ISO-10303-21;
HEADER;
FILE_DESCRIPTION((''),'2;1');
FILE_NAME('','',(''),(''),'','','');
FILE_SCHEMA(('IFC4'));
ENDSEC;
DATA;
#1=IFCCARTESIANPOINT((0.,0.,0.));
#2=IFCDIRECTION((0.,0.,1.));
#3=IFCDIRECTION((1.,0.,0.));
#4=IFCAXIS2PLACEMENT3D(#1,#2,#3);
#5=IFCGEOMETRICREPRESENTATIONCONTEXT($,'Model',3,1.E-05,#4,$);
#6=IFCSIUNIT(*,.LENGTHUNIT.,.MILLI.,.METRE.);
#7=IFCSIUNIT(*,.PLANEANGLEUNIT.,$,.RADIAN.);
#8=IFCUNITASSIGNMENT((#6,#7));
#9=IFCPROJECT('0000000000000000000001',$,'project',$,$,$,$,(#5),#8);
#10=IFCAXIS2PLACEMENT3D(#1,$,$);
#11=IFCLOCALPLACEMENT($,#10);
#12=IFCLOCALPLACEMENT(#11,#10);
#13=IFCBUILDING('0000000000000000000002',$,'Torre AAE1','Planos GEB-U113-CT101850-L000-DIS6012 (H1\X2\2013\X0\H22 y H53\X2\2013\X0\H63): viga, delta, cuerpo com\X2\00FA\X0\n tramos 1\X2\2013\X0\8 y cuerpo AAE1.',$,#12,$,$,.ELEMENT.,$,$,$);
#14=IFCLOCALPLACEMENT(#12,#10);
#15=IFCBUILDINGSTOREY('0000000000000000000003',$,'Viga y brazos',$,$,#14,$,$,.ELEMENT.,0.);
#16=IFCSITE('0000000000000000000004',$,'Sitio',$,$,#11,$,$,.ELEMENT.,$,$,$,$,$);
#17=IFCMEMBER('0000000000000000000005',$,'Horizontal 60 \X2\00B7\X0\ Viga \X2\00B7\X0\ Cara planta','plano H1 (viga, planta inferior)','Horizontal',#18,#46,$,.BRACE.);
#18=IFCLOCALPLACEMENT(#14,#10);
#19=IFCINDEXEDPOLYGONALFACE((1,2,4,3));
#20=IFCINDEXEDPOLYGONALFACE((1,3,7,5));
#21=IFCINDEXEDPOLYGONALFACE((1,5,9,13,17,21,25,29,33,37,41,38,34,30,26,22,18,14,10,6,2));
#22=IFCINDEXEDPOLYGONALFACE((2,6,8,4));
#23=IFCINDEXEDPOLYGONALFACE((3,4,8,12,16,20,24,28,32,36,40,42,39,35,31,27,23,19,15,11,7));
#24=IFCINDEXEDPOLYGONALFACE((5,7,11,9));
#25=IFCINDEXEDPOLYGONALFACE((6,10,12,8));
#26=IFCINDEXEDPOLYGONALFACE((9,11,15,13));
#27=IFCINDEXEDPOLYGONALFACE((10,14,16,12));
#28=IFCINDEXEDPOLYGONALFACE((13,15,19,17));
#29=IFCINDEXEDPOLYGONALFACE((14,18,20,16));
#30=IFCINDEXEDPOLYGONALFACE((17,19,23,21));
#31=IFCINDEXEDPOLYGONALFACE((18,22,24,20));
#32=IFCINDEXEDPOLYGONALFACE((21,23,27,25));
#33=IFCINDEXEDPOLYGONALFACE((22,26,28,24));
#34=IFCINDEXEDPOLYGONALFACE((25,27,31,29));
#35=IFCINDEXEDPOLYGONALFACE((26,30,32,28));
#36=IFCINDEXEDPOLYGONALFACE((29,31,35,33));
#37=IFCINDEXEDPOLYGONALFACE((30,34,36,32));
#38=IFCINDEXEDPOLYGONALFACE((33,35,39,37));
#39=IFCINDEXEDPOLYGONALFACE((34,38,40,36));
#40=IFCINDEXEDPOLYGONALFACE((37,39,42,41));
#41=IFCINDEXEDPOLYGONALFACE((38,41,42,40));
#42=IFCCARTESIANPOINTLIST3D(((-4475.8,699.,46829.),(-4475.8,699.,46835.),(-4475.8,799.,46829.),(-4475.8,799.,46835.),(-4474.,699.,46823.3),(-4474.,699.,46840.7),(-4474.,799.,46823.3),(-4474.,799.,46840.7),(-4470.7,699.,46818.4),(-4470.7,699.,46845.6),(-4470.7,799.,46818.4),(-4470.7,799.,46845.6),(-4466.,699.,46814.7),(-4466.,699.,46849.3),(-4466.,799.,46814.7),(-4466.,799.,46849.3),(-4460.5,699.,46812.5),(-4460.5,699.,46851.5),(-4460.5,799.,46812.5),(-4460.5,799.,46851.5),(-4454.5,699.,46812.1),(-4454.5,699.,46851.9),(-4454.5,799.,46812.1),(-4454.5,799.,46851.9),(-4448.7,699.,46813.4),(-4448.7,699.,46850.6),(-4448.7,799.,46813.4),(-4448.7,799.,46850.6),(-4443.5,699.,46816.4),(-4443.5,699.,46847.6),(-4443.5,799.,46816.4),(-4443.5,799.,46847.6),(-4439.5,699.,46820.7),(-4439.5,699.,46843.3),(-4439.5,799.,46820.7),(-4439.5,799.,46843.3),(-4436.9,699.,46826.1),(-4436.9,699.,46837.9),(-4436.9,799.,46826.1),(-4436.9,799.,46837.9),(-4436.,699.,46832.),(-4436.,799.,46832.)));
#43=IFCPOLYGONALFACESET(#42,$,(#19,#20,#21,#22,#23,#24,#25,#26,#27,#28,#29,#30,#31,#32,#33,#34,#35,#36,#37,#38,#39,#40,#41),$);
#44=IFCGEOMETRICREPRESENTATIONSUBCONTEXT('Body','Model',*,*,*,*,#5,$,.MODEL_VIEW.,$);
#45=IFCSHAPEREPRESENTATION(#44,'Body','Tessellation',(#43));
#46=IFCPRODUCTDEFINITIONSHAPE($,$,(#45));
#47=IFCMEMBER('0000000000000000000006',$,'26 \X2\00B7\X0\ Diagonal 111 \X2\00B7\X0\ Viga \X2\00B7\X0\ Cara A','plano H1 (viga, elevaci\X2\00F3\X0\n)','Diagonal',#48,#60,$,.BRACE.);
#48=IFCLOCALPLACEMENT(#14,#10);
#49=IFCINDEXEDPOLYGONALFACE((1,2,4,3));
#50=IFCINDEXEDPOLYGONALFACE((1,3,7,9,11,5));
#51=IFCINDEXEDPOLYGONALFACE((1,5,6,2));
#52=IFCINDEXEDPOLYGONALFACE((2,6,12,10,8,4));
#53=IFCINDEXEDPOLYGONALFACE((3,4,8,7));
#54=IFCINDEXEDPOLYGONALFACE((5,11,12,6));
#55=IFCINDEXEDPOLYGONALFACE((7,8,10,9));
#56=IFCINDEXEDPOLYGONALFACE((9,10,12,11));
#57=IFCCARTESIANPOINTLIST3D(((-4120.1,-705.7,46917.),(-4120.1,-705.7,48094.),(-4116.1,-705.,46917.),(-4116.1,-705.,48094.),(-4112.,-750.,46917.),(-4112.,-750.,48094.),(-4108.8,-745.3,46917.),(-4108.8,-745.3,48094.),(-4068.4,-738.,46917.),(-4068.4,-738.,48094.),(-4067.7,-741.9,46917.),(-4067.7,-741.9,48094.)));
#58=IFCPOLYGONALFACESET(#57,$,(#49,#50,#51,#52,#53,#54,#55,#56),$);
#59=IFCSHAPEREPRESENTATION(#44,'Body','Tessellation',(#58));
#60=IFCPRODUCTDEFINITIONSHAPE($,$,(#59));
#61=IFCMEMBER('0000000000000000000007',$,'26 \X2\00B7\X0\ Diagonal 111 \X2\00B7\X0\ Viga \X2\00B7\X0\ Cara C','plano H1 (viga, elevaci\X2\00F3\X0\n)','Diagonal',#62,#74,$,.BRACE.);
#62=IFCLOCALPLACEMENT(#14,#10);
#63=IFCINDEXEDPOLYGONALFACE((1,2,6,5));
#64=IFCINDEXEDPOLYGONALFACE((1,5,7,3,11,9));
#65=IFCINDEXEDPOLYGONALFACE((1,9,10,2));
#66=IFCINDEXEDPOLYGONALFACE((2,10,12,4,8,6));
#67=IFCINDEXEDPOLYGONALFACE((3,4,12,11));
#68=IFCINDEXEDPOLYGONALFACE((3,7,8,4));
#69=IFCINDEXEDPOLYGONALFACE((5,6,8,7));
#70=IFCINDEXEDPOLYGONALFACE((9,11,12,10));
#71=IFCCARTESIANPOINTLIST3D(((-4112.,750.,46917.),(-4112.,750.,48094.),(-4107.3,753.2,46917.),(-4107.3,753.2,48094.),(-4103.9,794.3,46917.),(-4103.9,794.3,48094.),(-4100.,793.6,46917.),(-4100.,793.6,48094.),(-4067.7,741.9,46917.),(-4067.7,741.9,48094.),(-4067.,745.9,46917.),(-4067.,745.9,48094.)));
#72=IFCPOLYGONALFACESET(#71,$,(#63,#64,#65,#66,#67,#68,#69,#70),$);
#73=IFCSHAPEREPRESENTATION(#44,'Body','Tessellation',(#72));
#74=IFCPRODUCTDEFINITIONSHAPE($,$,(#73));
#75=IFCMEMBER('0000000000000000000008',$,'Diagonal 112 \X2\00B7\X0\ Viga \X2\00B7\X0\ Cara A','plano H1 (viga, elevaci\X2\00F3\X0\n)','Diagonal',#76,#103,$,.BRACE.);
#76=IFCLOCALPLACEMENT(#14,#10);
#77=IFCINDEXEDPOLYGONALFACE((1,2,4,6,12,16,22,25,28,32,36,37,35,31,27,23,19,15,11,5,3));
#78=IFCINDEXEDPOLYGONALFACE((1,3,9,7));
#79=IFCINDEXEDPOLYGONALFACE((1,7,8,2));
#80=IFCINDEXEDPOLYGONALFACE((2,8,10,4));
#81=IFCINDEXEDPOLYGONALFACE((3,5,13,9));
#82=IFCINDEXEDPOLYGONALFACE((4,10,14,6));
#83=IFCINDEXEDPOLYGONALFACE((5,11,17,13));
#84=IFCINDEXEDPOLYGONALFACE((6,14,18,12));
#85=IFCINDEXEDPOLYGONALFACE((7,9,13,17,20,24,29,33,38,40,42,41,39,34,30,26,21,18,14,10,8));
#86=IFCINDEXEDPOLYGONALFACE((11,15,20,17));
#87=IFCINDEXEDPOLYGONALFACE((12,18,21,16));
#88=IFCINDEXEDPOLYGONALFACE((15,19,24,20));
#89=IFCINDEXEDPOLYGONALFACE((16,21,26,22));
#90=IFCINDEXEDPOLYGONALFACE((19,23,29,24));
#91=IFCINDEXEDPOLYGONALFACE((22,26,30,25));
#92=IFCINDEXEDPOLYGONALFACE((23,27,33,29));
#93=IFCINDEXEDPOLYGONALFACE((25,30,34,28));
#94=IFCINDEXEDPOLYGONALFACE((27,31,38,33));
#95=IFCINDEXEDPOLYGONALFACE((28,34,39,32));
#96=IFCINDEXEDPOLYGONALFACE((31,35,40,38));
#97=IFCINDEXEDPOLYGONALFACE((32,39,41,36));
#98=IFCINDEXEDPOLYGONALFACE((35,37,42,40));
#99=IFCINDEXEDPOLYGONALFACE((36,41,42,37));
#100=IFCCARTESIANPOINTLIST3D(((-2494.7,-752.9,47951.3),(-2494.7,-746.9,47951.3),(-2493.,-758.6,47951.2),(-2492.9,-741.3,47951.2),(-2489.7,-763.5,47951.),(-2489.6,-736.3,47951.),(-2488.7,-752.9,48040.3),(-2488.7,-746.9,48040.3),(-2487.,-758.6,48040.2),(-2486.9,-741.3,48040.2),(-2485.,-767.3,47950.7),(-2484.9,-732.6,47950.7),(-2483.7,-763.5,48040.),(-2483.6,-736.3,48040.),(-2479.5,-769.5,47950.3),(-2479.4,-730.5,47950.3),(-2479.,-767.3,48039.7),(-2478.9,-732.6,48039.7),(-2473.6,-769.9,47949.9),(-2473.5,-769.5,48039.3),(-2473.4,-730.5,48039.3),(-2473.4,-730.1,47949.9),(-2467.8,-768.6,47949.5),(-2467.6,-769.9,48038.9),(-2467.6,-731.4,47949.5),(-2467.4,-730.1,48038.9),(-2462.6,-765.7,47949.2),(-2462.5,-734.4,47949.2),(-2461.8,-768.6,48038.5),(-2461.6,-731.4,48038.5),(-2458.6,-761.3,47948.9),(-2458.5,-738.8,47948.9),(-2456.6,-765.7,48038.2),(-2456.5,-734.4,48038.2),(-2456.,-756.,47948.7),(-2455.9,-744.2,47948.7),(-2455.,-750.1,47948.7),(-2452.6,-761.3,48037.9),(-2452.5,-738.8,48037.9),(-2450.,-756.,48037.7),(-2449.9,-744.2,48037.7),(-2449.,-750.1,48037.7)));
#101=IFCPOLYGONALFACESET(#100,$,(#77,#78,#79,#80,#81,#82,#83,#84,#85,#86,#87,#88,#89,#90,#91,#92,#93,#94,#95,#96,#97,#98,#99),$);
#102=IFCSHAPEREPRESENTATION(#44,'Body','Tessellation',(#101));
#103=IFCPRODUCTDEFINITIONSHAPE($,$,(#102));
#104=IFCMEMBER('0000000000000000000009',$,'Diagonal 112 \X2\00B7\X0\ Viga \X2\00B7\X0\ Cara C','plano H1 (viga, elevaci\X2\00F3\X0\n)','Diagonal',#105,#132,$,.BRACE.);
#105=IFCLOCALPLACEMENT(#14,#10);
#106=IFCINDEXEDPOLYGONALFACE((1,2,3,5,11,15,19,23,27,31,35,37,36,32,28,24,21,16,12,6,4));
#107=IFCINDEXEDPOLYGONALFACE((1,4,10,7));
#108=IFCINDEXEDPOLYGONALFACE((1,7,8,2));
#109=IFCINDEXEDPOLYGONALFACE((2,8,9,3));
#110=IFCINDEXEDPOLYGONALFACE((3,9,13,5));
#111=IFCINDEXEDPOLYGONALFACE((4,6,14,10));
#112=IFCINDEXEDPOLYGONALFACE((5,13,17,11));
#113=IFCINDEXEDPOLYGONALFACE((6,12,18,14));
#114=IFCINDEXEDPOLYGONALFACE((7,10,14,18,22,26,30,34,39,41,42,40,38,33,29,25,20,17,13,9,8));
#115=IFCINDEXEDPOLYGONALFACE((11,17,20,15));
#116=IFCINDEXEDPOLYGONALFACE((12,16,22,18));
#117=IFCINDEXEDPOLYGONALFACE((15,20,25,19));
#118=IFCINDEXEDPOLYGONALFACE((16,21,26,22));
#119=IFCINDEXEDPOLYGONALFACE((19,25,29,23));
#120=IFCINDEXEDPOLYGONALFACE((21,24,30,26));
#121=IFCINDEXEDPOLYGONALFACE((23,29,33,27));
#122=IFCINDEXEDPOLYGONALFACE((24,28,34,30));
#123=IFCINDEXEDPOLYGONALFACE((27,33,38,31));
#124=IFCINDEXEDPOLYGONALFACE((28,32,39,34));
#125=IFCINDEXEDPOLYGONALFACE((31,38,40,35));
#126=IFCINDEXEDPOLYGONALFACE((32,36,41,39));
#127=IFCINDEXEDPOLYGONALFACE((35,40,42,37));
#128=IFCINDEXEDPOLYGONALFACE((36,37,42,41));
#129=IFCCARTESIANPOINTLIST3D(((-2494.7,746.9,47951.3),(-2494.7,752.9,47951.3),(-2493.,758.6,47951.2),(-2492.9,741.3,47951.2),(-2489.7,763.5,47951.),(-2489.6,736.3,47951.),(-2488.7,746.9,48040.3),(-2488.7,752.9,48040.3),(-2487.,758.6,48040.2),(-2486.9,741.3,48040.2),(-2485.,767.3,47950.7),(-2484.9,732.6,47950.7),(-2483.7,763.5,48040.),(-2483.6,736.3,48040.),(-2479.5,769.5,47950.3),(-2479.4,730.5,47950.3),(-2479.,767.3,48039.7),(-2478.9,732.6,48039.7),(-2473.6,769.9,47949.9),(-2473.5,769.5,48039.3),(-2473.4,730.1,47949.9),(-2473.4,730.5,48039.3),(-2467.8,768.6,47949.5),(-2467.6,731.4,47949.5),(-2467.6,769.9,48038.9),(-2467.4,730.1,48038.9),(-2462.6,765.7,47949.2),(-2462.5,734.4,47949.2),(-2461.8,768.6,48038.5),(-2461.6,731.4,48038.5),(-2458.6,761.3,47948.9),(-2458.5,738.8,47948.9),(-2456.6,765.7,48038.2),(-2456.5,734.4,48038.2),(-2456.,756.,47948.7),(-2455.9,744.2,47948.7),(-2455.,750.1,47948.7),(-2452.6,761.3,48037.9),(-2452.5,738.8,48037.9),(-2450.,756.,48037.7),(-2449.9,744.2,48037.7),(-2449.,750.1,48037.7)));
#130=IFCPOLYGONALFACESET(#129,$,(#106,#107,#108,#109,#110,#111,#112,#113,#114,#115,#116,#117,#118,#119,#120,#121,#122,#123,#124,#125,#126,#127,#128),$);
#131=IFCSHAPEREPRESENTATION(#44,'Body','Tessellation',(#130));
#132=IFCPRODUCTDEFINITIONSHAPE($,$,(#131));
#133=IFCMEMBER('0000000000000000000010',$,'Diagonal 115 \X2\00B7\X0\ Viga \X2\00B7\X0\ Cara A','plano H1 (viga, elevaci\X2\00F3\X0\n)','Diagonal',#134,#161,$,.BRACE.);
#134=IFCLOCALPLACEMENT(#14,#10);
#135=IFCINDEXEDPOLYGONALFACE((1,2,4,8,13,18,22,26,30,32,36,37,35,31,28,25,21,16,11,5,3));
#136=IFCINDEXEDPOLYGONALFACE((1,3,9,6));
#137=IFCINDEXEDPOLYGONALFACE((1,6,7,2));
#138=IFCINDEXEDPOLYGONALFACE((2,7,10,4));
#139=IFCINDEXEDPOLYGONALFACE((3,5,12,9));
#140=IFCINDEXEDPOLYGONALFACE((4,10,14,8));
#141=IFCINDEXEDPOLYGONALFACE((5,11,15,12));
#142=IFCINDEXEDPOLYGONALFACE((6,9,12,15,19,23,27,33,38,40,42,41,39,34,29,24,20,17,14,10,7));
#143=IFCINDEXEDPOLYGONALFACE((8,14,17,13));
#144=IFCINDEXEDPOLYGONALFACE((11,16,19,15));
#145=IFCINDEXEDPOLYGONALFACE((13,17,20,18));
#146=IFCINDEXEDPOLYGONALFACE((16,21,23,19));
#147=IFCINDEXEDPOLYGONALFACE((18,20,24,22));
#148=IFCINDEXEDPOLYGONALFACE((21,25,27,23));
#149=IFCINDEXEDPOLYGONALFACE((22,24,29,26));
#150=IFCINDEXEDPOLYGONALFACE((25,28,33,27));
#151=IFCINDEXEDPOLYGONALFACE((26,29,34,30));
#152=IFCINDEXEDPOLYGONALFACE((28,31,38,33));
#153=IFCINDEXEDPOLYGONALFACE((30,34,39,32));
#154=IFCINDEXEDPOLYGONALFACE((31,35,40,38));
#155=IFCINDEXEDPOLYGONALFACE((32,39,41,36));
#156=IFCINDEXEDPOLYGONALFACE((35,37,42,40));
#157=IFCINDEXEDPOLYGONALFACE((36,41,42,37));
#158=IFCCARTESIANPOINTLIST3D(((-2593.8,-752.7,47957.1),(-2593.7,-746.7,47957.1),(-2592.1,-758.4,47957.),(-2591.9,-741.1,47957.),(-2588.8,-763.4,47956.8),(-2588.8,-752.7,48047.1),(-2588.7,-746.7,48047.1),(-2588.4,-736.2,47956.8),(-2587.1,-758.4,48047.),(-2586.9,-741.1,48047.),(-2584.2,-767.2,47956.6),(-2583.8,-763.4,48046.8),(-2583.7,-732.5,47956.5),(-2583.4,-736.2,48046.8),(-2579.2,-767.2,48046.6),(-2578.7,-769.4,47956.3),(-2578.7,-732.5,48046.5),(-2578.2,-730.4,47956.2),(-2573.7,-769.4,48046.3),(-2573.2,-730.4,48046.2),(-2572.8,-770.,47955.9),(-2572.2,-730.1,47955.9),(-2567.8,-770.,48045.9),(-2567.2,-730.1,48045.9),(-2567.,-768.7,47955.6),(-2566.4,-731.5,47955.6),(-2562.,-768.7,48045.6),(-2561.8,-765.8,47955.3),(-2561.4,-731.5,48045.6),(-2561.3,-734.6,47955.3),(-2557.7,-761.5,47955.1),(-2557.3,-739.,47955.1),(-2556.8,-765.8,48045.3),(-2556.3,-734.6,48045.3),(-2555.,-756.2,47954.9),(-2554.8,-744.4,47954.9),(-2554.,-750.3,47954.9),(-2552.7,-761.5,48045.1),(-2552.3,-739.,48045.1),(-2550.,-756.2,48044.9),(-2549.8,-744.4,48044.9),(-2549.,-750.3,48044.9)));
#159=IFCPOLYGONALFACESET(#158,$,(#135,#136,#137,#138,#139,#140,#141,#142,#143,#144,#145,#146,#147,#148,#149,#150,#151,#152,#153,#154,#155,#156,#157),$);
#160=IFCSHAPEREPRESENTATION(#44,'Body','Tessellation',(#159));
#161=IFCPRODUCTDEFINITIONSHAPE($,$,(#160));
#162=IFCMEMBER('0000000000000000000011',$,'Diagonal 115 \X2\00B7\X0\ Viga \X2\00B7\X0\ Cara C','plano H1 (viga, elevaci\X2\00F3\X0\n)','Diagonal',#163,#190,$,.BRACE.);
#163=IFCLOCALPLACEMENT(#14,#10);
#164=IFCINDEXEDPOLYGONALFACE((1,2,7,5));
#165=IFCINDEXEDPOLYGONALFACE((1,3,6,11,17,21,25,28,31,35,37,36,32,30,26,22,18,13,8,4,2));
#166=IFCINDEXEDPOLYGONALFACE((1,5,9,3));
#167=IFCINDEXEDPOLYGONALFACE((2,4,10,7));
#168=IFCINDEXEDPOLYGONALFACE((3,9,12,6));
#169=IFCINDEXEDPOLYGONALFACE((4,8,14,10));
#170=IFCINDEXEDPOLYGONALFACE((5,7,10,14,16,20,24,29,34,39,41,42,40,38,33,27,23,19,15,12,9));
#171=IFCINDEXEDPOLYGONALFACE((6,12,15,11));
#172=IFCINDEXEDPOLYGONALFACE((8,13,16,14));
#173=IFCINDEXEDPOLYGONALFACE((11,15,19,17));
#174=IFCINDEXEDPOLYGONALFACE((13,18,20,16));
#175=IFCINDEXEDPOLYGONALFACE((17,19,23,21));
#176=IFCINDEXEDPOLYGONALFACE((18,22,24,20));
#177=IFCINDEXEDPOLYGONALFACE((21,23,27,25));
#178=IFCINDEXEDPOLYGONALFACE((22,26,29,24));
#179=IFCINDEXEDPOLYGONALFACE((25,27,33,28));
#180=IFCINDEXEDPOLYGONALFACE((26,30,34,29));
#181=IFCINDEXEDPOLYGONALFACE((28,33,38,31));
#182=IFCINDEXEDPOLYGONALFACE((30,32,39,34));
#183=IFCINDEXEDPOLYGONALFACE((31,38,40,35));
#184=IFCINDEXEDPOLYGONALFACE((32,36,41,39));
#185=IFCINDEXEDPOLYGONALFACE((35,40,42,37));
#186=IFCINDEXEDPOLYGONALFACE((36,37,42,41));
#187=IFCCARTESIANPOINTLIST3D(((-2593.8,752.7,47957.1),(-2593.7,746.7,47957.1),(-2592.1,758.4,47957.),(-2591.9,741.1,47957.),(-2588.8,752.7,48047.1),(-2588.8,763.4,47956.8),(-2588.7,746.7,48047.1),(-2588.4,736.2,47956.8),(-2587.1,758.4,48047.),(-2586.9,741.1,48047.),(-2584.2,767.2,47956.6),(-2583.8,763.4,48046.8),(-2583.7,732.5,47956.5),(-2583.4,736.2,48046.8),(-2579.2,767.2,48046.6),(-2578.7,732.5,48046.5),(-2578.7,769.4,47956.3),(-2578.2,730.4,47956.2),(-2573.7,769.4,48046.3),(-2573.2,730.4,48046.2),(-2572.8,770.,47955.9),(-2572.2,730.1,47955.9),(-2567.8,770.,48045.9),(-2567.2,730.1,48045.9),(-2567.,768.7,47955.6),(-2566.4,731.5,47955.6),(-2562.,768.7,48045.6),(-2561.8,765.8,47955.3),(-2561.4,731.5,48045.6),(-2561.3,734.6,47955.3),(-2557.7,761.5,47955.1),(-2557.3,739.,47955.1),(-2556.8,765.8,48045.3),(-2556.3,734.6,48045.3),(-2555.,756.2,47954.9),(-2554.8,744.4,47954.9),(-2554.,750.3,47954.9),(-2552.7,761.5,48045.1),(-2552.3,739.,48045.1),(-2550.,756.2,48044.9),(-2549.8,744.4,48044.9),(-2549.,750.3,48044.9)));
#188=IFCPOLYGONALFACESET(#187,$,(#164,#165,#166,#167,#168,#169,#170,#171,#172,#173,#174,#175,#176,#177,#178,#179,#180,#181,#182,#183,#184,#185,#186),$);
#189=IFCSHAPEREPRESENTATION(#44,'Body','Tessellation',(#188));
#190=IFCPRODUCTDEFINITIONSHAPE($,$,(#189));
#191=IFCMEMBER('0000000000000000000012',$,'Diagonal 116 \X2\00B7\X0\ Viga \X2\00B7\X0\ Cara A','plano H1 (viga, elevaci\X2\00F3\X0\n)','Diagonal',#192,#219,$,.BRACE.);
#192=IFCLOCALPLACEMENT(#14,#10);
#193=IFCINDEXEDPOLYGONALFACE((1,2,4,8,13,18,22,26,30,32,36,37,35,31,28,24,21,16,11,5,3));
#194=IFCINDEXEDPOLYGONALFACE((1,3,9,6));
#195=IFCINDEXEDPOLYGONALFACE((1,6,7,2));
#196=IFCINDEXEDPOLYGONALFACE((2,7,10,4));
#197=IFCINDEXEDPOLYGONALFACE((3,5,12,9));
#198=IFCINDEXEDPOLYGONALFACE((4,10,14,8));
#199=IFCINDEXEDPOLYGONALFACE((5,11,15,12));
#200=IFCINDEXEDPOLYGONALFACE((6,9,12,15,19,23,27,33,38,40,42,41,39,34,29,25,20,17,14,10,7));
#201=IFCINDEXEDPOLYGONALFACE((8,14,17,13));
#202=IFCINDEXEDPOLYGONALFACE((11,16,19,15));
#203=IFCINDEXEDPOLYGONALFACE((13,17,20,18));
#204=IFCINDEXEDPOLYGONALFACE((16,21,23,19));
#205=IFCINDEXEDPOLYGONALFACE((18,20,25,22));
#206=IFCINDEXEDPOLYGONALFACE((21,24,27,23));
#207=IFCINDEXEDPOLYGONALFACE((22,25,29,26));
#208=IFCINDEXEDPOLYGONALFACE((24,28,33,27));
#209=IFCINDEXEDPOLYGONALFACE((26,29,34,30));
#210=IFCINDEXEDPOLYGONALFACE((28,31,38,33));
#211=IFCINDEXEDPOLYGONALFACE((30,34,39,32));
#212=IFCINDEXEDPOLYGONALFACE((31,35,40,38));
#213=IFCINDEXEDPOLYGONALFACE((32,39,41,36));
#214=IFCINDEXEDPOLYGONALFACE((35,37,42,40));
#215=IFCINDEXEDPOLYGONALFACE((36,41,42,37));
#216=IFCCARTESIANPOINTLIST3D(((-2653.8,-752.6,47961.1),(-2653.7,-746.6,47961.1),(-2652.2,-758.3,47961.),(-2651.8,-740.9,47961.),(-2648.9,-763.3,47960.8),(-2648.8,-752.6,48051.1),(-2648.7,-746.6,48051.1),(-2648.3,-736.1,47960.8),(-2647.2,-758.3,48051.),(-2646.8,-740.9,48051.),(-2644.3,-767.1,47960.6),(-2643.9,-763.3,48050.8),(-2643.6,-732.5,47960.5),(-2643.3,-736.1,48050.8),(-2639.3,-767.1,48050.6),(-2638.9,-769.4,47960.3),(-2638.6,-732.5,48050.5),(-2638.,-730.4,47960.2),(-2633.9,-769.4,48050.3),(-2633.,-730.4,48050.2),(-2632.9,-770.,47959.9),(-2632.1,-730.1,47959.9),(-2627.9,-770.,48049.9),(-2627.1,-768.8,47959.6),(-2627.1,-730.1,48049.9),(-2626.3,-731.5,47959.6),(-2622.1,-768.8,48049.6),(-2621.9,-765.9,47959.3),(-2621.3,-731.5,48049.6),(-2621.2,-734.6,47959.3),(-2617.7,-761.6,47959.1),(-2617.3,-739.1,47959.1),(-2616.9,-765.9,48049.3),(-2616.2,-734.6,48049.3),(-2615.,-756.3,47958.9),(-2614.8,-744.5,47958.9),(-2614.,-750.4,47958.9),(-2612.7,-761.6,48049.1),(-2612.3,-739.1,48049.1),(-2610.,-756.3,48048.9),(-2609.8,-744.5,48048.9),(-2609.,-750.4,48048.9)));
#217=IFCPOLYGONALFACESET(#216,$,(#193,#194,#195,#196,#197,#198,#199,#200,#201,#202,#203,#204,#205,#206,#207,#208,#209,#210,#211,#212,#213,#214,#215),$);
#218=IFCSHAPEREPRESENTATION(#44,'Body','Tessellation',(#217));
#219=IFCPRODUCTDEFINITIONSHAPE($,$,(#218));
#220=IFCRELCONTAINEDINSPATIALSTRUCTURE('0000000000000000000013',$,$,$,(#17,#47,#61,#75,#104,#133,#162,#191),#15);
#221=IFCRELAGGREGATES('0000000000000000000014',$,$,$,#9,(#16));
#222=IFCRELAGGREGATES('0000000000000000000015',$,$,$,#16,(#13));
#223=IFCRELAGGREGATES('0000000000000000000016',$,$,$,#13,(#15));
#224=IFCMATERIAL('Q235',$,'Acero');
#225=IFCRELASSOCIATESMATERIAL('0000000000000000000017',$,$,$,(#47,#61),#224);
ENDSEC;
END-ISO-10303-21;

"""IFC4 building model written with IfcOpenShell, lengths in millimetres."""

from ifc_helpers import new_model, si_unit, frame, frame_2d, origin, origin_with_axes, place, context, subcontext, project, spatial, circle, l_section, extrude, material, element, save


model = new_model("IFC4")

# Units and contexts
model_context = context("Model", 3, precision=1e-05, world=origin_with_axes())
body_context = subcontext(model_context, "Body", "Model", "MODEL_VIEW")
ifc_project = project(units=[si_unit("LENGTHUNIT", "METRE", prefix="MILLI"), si_unit("PLANEANGLEUNIT", "RADIAN")], contexts=[model_context])

# Site, building, storey
site_placement = place(None, origin())
site = spatial("IfcSite", under=ifc_project, at=site_placement, Name="Sitio", CompositionType="ELEMENT")
building_placement = place(site_placement, origin())
building = spatial("IfcBuilding", under=site, at=building_placement, Name="Torre AAE1", Description="Planos GEB-U113-CT101850-L000-DIS6012 (H1–H22 y H53–H63): viga, delta, cuerpo común tramos 1–8 y cuerpo AAE1.", CompositionType="ELEMENT")
storey_placement = place(building_placement, origin())
storey = spatial("IfcBuildingStorey", under=building, at=storey_placement, Name="Viga y brazos", CompositionType="ELEMENT", Elevation=0.0)

# Members
ifc_material = material(Name="Q235", Category="Acero")
member_1_placement = place(storey_placement, frame((-4456.0, 699.0, 46832.0), z_axis=(0.0, 1.0, 0.0), x_axis=(1.0, 0.0, 0.0)))
element("IfcMember", 1, at=member_1_placement, inside=storey, Name="Horizontal 60 · Viga · Cara planta", Description="plano H1 (viga, planta inferior)", ObjectType="Horizontal", PredefinedType="BRACE", context=body_context, shape_type="SweptSolid", body=[
    extrude(circle(Radius=20.0), None, (0.0, 0.0, 1.0), 100.0),
])
for number, where, z_axis, x_axis, name in (
    (2, (-4112.0, -750.0, 46917.0), (0.0, 0.0, 1.0), (0.98377, 0.179433, 0.0), "26 · Diagonal 111 · Viga · Cara A"),
    (3, (-4112.0, 750.0, 46917.0), (0.0, 0.0, 1.0), (0.98377, -0.179433, 0.0), "26 · Diagonal 111 · Viga · Cara C"),
):
    element("IfcMember", number, at=place(storey_placement, frame(where, z_axis=z_axis, x_axis=x_axis)), inside=storey, material=ifc_material, Name=name, Description="plano H1 (viga, elevación)", ObjectType="Diagonal", PredefinedType="BRACE", context=body_context, shape_type="SweptSolid", body=[
        extrude(l_section(Depth=45.0, Width=45.0, Thickness=4.0, at=frame_2d((22.5, 22.5))), None, (0.0, 0.0, 1.0), 1177.0),
    ])
for number, where, z_axis, x_axis, name in (
    (4, (-2475.0, -750.0, 47950.0), (0.067263, 0.0, 0.997735), (0.954577, 0.290933, -0.064353), "Diagonal 112 · Viga · Cara A"),
    (5, (-2475.0, 750.0, 47950.0), (0.067263, 0.0, 0.997735), (0.954577, -0.290933, -0.064353), "Diagonal 112 · Viga · Cara C"),
):
    element("IfcMember", number, at=place(storey_placement, frame(where, z_axis=z_axis, x_axis=x_axis)), inside=storey, Name=name, Description="plano H1 (viga, elevación)", ObjectType="Diagonal", PredefinedType="BRACE", context=body_context, shape_type="SweptSolid", body=[
        extrude(circle(Radius=20.0), None, (0.0, 0.0, 1.0), 89.2),
    ])
for number, where, z_axis, x_axis, name in (
    (6, (-2574.0, -750.0, 47956.0), (0.05547, 0.0, 0.99846), (0.958408, 0.280391, -0.053245), "Diagonal 115 · Viga · Cara A"),
    (7, (-2574.0, 750.0, 47956.0), (0.05547, 0.0, 0.99846), (0.958408, -0.280391, -0.053245), "Diagonal 115 · Viga · Cara C"),
    (8, (-2634.0, -750.0, 47960.0), (0.05547, 0.0, 0.99846), (0.960111, 0.274484, -0.05334), "Diagonal 116 · Viga · Cara A"),
):
    element("IfcMember", number, at=place(storey_placement, frame(where, z_axis=z_axis, x_axis=x_axis)), inside=storey, Name=name, Description="plano H1 (viga, elevación)", ObjectType="Diagonal", PredefinedType="BRACE", context=body_context, shape_type="SweptSolid", body=[
        extrude(circle(Radius=20.0), None, (0.0, 0.0, 1.0), 90.1),
    ])

save(model, "model.ifc")
